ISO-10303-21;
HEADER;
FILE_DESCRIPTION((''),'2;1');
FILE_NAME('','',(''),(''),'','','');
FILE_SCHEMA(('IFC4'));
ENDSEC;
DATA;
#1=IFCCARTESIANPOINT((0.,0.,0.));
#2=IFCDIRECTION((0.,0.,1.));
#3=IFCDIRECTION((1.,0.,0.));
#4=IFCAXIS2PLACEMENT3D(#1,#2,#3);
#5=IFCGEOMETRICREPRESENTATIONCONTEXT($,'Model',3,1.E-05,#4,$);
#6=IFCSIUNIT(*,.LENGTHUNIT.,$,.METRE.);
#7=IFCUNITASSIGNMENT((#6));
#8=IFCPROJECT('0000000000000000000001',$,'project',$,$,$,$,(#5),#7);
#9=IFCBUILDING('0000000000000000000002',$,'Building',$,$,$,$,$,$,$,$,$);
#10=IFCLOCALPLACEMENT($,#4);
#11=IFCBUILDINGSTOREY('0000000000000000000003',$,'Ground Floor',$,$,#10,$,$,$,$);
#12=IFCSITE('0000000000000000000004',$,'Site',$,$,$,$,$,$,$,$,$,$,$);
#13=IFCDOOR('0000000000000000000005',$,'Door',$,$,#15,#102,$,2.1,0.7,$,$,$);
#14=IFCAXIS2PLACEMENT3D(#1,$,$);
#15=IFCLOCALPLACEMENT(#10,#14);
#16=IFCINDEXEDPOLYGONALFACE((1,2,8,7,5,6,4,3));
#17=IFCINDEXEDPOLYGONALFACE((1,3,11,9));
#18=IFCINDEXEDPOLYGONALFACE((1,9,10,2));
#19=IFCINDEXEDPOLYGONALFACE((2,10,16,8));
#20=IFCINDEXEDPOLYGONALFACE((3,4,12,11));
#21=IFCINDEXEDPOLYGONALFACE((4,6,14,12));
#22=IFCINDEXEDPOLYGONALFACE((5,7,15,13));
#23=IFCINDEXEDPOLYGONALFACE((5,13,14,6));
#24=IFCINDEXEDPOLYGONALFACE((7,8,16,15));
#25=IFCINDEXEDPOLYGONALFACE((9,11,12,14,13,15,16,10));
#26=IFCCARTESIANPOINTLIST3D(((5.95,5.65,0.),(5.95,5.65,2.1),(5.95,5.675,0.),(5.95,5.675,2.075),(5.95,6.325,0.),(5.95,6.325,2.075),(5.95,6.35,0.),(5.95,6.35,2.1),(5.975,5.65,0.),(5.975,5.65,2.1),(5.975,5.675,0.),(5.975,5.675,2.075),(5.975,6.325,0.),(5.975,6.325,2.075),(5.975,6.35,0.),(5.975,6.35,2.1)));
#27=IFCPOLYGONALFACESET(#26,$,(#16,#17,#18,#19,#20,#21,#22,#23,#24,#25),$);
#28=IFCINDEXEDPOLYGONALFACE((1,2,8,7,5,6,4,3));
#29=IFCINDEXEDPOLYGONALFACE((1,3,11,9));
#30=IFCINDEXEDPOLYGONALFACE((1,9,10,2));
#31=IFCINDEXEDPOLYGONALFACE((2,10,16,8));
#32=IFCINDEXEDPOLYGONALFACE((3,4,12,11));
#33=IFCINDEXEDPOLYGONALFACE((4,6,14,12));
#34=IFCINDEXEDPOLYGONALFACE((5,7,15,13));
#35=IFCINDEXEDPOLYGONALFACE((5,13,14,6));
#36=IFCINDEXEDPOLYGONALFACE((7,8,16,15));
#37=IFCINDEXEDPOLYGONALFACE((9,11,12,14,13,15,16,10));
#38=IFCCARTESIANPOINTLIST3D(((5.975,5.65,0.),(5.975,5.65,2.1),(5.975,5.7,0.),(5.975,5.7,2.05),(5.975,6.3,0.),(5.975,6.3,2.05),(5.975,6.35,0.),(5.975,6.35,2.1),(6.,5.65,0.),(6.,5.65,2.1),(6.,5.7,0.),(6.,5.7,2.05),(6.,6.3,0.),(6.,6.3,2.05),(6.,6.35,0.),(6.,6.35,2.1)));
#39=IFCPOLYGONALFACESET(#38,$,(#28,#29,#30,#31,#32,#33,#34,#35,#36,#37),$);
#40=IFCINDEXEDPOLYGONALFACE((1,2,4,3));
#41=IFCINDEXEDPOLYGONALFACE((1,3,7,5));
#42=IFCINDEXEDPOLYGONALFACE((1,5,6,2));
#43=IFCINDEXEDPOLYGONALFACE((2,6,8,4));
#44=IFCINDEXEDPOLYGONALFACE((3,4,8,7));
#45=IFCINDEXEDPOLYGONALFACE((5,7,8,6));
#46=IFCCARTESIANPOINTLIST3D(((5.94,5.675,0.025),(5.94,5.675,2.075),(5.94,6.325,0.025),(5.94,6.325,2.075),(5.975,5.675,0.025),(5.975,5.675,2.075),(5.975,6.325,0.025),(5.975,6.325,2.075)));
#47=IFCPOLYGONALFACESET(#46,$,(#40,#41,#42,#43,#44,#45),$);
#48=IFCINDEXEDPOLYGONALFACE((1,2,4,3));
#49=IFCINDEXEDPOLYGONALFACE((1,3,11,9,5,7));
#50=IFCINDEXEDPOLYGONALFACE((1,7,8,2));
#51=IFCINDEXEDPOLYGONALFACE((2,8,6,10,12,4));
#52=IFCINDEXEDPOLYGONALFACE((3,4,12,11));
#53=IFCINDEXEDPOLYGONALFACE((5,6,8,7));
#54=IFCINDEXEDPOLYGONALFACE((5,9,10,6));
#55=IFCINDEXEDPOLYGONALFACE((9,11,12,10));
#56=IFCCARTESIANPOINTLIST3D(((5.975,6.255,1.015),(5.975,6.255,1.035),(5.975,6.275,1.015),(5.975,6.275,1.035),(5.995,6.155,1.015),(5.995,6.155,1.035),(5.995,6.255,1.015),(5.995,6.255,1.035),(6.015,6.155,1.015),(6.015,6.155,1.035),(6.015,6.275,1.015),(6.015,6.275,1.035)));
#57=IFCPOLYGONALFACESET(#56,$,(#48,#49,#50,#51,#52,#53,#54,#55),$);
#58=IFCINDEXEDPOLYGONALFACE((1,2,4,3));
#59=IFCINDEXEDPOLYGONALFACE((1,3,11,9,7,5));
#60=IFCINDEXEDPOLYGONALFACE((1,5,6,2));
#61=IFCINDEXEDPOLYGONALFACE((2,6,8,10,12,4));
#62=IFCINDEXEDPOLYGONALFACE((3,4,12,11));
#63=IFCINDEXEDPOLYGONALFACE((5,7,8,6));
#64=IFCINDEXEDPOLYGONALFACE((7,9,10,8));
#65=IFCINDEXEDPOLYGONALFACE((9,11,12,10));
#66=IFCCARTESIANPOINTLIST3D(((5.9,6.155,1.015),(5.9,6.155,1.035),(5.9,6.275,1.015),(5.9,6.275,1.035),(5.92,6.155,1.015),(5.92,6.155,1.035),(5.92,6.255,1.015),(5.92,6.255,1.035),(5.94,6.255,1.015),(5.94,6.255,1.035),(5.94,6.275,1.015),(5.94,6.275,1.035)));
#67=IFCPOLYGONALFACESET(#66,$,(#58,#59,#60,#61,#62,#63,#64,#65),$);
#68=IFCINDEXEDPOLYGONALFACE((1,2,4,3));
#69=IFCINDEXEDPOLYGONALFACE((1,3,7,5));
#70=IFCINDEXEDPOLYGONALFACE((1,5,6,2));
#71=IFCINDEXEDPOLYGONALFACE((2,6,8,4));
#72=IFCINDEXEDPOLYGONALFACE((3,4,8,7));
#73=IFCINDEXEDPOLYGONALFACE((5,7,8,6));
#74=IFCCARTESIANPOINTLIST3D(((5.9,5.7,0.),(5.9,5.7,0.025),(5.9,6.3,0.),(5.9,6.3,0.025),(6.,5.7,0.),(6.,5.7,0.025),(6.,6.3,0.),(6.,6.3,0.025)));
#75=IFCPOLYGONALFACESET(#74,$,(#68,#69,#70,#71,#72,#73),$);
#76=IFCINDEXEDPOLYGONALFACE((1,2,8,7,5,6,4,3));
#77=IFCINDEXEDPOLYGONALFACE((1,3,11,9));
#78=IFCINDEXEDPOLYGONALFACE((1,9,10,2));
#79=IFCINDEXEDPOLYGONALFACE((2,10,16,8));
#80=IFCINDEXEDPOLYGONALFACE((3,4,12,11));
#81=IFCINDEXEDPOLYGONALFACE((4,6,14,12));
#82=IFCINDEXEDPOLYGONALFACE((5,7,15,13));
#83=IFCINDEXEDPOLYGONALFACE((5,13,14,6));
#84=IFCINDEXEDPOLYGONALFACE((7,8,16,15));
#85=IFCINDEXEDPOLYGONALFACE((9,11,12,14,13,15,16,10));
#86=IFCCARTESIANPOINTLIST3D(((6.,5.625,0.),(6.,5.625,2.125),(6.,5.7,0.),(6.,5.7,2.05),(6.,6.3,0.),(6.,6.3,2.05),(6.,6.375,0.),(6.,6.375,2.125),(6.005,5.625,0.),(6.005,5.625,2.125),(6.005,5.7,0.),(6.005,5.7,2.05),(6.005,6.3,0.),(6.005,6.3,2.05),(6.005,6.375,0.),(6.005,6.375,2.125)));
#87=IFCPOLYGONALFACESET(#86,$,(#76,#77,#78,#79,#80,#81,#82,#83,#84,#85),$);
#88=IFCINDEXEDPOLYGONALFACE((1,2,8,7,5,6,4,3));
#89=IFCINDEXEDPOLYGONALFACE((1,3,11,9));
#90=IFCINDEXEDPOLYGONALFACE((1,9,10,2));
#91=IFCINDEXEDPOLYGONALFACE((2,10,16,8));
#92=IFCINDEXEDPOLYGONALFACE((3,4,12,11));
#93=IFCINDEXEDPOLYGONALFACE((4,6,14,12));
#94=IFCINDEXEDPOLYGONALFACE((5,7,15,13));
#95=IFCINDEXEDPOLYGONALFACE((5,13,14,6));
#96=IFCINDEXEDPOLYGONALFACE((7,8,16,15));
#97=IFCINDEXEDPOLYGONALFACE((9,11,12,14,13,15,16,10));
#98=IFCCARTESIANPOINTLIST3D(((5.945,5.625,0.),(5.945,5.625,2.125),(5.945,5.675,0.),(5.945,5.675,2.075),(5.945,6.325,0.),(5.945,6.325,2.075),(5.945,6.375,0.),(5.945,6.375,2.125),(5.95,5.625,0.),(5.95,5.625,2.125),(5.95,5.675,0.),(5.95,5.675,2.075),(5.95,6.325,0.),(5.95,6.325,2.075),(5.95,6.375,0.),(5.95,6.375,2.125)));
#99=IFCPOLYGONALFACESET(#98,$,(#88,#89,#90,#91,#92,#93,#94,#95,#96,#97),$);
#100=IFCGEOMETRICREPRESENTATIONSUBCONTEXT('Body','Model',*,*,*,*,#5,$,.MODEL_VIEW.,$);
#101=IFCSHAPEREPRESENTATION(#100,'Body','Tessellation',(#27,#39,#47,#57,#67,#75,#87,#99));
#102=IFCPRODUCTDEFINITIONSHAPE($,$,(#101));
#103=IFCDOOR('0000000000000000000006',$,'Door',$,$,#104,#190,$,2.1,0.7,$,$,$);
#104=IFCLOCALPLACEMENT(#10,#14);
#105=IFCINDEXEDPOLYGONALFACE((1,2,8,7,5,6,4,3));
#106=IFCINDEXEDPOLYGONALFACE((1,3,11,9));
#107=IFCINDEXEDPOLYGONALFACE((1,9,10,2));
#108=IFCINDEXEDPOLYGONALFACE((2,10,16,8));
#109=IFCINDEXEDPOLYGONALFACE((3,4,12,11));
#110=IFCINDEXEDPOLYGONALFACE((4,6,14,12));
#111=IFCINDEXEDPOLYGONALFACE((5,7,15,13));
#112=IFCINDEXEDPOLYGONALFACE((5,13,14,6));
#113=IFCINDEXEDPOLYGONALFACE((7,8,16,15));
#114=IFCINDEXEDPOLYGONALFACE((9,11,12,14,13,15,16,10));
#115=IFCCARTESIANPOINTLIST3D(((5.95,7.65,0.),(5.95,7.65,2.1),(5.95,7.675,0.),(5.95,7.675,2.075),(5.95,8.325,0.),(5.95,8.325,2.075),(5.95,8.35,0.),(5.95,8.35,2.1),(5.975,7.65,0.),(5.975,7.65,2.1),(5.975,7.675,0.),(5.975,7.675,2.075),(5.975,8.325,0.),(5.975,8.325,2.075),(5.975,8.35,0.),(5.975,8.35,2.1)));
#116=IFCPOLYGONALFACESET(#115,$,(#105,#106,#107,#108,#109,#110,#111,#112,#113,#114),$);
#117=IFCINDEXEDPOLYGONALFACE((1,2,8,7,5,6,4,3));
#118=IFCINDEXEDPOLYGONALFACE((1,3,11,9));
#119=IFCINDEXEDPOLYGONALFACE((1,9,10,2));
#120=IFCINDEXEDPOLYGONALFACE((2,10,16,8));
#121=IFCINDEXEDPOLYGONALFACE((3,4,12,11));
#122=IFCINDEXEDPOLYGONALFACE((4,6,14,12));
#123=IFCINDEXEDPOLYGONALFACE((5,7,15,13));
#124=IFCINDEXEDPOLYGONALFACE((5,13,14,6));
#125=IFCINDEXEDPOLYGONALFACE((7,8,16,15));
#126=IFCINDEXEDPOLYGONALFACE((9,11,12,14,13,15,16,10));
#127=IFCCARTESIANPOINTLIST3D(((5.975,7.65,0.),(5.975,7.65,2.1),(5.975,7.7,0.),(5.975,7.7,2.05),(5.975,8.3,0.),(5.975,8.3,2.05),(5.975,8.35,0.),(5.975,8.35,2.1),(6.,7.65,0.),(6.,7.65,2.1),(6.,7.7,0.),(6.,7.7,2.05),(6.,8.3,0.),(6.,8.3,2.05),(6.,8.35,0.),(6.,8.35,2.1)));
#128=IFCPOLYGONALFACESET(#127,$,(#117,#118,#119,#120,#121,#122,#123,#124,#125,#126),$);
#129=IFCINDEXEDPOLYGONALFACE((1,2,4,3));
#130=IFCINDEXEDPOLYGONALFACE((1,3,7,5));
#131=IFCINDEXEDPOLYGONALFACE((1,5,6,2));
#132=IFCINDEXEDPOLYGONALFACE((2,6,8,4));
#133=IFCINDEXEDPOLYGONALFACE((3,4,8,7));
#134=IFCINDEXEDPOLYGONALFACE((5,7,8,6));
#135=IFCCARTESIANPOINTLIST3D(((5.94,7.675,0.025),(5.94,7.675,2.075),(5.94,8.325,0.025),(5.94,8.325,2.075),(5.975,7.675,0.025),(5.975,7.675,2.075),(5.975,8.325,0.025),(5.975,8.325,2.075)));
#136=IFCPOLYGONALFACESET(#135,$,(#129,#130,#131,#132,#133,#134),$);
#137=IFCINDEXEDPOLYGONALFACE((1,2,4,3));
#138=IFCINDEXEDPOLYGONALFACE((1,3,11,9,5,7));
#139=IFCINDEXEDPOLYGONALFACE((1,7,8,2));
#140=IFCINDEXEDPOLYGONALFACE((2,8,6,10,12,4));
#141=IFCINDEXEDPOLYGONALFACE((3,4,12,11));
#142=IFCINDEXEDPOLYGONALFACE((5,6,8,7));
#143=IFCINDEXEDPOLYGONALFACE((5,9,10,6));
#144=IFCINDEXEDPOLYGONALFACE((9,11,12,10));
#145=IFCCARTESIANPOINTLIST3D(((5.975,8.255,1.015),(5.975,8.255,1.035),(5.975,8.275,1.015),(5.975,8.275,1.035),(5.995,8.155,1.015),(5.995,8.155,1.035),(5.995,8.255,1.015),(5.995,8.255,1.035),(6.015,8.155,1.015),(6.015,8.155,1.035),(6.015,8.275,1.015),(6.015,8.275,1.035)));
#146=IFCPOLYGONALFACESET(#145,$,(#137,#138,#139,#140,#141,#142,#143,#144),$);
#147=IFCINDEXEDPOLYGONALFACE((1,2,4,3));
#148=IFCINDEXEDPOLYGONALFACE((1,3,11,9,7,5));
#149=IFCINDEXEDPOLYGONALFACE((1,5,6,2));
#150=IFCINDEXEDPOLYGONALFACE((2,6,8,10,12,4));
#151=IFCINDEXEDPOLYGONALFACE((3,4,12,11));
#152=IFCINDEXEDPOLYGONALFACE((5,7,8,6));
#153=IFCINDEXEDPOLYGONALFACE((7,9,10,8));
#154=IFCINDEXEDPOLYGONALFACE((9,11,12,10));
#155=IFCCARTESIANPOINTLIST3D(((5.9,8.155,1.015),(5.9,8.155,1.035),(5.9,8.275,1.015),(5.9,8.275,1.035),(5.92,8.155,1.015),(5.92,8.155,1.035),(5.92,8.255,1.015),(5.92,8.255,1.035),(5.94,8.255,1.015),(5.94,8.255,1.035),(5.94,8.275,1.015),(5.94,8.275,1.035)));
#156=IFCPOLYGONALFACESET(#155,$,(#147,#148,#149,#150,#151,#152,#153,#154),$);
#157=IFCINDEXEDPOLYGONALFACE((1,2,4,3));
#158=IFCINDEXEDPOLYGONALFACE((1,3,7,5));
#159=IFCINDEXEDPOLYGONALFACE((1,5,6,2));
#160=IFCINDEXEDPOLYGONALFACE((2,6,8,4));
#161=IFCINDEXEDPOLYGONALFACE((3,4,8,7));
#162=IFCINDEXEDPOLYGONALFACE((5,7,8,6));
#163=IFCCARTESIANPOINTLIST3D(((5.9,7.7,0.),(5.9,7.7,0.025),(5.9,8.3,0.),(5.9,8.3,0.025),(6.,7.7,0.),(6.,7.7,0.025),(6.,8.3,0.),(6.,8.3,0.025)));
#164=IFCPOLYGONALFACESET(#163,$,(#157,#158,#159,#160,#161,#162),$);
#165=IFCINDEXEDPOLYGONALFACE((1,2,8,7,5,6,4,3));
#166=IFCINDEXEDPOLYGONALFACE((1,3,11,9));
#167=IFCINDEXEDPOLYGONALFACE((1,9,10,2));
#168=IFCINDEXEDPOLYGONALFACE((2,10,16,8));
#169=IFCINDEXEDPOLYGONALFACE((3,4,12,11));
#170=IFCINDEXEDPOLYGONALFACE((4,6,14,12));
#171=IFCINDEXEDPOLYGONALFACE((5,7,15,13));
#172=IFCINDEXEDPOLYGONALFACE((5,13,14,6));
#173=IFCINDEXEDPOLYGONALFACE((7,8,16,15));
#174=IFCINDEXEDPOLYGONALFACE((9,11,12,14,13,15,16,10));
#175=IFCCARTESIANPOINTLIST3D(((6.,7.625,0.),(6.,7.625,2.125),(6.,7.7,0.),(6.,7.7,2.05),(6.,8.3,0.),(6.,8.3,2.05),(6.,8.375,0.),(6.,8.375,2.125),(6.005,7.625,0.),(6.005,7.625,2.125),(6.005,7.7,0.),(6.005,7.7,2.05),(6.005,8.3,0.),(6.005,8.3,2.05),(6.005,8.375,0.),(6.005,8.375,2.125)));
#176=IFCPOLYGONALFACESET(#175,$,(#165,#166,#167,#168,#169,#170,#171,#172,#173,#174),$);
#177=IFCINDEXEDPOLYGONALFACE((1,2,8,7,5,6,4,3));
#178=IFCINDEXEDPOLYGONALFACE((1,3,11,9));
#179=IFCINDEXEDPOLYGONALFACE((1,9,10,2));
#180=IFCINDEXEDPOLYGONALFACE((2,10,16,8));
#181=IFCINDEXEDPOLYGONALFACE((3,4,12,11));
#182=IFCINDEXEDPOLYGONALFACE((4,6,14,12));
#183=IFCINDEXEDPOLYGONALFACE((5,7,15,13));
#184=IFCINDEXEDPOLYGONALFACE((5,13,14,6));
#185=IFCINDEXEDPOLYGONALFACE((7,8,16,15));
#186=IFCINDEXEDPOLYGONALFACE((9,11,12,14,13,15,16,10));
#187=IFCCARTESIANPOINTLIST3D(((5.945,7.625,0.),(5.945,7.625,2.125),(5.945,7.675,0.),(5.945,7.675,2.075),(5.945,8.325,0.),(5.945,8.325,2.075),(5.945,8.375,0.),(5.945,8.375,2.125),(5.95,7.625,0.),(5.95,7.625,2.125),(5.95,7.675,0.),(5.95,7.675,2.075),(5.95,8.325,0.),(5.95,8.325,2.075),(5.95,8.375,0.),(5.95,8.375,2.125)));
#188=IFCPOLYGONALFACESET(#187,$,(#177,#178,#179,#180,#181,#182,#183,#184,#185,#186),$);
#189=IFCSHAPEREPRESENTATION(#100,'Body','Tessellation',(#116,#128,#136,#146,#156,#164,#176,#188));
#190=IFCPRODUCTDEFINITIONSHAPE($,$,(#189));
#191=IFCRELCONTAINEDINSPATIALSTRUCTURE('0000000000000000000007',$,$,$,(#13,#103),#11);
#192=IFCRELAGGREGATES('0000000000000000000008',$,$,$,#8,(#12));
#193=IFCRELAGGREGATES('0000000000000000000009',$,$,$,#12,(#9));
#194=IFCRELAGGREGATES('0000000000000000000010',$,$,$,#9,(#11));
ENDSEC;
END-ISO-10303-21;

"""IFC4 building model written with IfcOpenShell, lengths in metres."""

from ifc_helpers import new_model, si_unit, frame, origin_with_axes, place, context, subcontext, project, spatial, line, indexed_curve, outline, extrude, element, save


model = new_model("IFC4")

# Units and contexts
model_context = context("Model", 3, precision=1e-05, world=origin_with_axes())
body_context = subcontext(model_context, "Body", "Model", "MODEL_VIEW")
ifc_project = project(units=[si_unit("LENGTHUNIT", "METRE")], contexts=[model_context])

# Site, building, storey
site = spatial("IfcSite", under=ifc_project, Name="Site")
building = spatial("IfcBuilding", under=site, Name="Building")
storey_placement = place(None, origin_with_axes())
storey = spatial("IfcBuildingStorey", under=building, at=storey_placement, Name="Ground Floor")

# Doors
door_1_placement = place(storey_placement, frame((6.0, 5.65, 0.0), z_axis=(0.0, 0.0, 1.0), x_axis=(0.0, 1.0, 0.0)))
element("IfcDoor", 1, at=door_1_placement, inside=storey, Name="Door", OverallHeight=2.1, OverallWidth=0.7, context=body_context, shape_type="SweptSolid", body=[
    extrude(outline(indexed_curve([(0.0, 0.0), (0.0, 2.1), (0.7, 2.1), (0.7, 0.0), (0.675, 0.0), (0.675, 2.075), (0.025, 2.075), (0.025, 0.0)], segments=[line(1, 2, 3, 4, 5, 6, 7, 8, 1)])), frame((0.0, 0.025, 0.0), z_axis=(0.0, -1.0, 0.0), x_axis=(1.0, 0.0, 0.0)), (0.0, 0.0, -1.0), 0.025),
    extrude(outline(indexed_curve([(0.0, 0.0), (0.0, 2.1), (0.7, 2.1), (0.7, 0.0), (0.65, 0.0), (0.65, 2.05), (0.05, 2.05), (0.05, 0.0)], segments=[line(1, 2, 3, 4, 5, 6, 7, 8, 1)])), frame((0.0, 0.0, 0.0), z_axis=(0.0, -1.0, 0.0), x_axis=(1.0, 0.0, 0.0)), (0.0, 0.0, -1.0), 0.025),
    extrude(outline(indexed_curve([(0.0, 0.0), (0.65, 0.0), (0.65, 0.035), (0.0, 0.035)], segments=[line(1, 2, 3, 4, 1)])), frame((0.025, 0.025, 0.025), z_axis=(0.0, 0.0, 1.0), x_axis=(1.0, 0.0, 0.0)), (0.0, 0.0, 1.0), 2.05),
    extrude(outline(indexed_curve([(0.0, 0.0), (0.0, -0.04), (-0.12, -0.04), (-0.12, -0.02), (-0.02, -0.02), (-0.02, 0.0)], segments=[line(1, 2, 3, 4, 5, 6, 1)])), frame((0.625, 0.025, 1.015), z_axis=(0.0, 0.0, 1.0), x_axis=(1.0, 0.0, 0.0)), (0.0, 0.0, 1.0), 0.02),
    extrude(outline(indexed_curve([(0.0, 0.0), (0.0, 0.04), (-0.12, 0.04), (-0.12, 0.02), (-0.02, 0.02), (-0.02, 0.0)], segments=[line(1, 2, 3, 4, 5, 6, 1)])), frame((0.625, 0.06, 1.015), z_axis=(0.0, 0.0, 1.0), x_axis=(1.0, 0.0, 0.0)), (0.0, 0.0, 1.0), 0.02),
    extrude(outline(indexed_curve([(0.0, 0.0), (0.6, 0.0), (0.6, 0.1), (0.0, 0.1)], segments=[line(1, 2, 3, 4, 1)])), frame((0.05, 0.0, 0.0), z_axis=(0.0, 0.0, 1.0), x_axis=(1.0, 0.0, 0.0)), (0.0, 0.0, 1.0), 0.025),
    extrude(outline(indexed_curve([(0.0, 0.0), (0.0, 2.125), (0.75, 2.125), (0.75, 0.0), (0.675, 0.0), (0.675, 2.05), (0.075, 2.05), (0.075, 0.0)], segments=[line(1, 2, 3, 4, 5, 6, 7, 8, 1)])), frame((-0.025, -0.005, 0.0), z_axis=(0.0, -1.0, 0.0), x_axis=(1.0, 0.0, 0.0)), (0.0, 0.0, -1.0), 0.005),
    extrude(outline(indexed_curve([(0.0, 0.0), (0.0, 2.125), (0.75, 2.125), (0.75, 0.0), (0.7, 0.0), (0.7, 2.075), (0.05, 2.075), (0.05, 0.0)], segments=[line(1, 2, 3, 4, 5, 6, 7, 8, 1)])), frame((-0.025, 0.05, 0.0), z_axis=(0.0, -1.0, 0.0), x_axis=(1.0, 0.0, 0.0)), (0.0, 0.0, -1.0), 0.005),
])
door_2_placement = place(storey_placement, frame((6.0, 7.65, 0.0), z_axis=(0.0, 0.0, 1.0), x_axis=(0.0, 1.0, 0.0)))
element("IfcDoor", 2, at=door_2_placement, inside=storey, Name="Door", OverallHeight=2.1, OverallWidth=0.7, context=body_context, shape_type="SweptSolid", body=[
    extrude(outline(indexed_curve([(0.0, 0.0), (0.0, 2.1), (0.7, 2.1), (0.7, 0.0), (0.675, 0.0), (0.675, 2.075), (0.025, 2.075), (0.025, 0.0)], segments=[line(1, 2, 3, 4, 5, 6, 7, 8, 1)])), frame((0.0, 0.025, 0.0), z_axis=(0.0, -1.0, 0.0), x_axis=(1.0, 0.0, 0.0)), (0.0, 0.0, -1.0), 0.025),
    extrude(outline(indexed_curve([(0.0, 0.0), (0.0, 2.1), (0.7, 2.1), (0.7, 0.0), (0.65, 0.0), (0.65, 2.05), (0.05, 2.05), (0.05, 0.0)], segments=[line(1, 2, 3, 4, 5, 6, 7, 8, 1)])), frame((0.0, 0.0, 0.0), z_axis=(0.0, -1.0, 0.0), x_axis=(1.0, 0.0, 0.0)), (0.0, 0.0, -1.0), 0.025),
    extrude(outline(indexed_curve([(0.0, 0.0), (0.65, 0.0), (0.65, 0.035), (0.0, 0.035)], segments=[line(1, 2, 3, 4, 1)])), frame((0.025, 0.025, 0.025), z_axis=(0.0, 0.0, 1.0), x_axis=(1.0, 0.0, 0.0)), (0.0, 0.0, 1.0), 2.05),
    extrude(outline(indexed_curve([(0.0, 0.0), (0.0, -0.04), (-0.12, -0.04), (-0.12, -0.02), (-0.02, -0.02), (-0.02, 0.0)], segments=[line(1, 2, 3, 4, 5, 6, 1)])), frame((0.625, 0.025, 1.015), z_axis=(0.0, 0.0, 1.0), x_axis=(1.0, 0.0, 0.0)), (0.0, 0.0, 1.0), 0.02),
    extrude(outline(indexed_curve([(0.0, 0.0), (0.0, 0.04), (-0.12, 0.04), (-0.12, 0.02), (-0.02, 0.02), (-0.02, 0.0)], segments=[line(1, 2, 3, 4, 5, 6, 1)])), frame((0.625, 0.06, 1.015), z_axis=(0.0, 0.0, 1.0), x_axis=(1.0, 0.0, 0.0)), (0.0, 0.0, 1.0), 0.02),
    extrude(outline(indexed_curve([(0.0, 0.0), (0.6, 0.0), (0.6, 0.1), (0.0, 0.1)], segments=[line(1, 2, 3, 4, 1)])), frame((0.05, 0.0, 0.0), z_axis=(0.0, 0.0, 1.0), x_axis=(1.0, 0.0, 0.0)), (0.0, 0.0, 1.0), 0.025),
    extrude(outline(indexed_curve([(0.0, 0.0), (0.0, 2.125), (0.75, 2.125), (0.75, 0.0), (0.675, 0.0), (0.675, 2.05), (0.075, 2.05), (0.075, 0.0)], segments=[line(1, 2, 3, 4, 5, 6, 7, 8, 1)])), frame((-0.025, -0.005, 0.0), z_axis=(0.0, -1.0, 0.0), x_axis=(1.0, 0.0, 0.0)), (0.0, 0.0, -1.0), 0.005),
    extrude(outline(indexed_curve([(0.0, 0.0), (0.0, 2.125), (0.75, 2.125), (0.75, 0.0), (0.7, 0.0), (0.7, 2.075), (0.05, 2.075), (0.05, 0.0)], segments=[line(1, 2, 3, 4, 5, 6, 7, 8, 1)])), frame((-0.025, 0.05, 0.0), z_axis=(0.0, -1.0, 0.0), x_axis=(1.0, 0.0, 0.0)), (0.0, 0.0, -1.0), 0.005),
])

save(model, "model.ifc")
